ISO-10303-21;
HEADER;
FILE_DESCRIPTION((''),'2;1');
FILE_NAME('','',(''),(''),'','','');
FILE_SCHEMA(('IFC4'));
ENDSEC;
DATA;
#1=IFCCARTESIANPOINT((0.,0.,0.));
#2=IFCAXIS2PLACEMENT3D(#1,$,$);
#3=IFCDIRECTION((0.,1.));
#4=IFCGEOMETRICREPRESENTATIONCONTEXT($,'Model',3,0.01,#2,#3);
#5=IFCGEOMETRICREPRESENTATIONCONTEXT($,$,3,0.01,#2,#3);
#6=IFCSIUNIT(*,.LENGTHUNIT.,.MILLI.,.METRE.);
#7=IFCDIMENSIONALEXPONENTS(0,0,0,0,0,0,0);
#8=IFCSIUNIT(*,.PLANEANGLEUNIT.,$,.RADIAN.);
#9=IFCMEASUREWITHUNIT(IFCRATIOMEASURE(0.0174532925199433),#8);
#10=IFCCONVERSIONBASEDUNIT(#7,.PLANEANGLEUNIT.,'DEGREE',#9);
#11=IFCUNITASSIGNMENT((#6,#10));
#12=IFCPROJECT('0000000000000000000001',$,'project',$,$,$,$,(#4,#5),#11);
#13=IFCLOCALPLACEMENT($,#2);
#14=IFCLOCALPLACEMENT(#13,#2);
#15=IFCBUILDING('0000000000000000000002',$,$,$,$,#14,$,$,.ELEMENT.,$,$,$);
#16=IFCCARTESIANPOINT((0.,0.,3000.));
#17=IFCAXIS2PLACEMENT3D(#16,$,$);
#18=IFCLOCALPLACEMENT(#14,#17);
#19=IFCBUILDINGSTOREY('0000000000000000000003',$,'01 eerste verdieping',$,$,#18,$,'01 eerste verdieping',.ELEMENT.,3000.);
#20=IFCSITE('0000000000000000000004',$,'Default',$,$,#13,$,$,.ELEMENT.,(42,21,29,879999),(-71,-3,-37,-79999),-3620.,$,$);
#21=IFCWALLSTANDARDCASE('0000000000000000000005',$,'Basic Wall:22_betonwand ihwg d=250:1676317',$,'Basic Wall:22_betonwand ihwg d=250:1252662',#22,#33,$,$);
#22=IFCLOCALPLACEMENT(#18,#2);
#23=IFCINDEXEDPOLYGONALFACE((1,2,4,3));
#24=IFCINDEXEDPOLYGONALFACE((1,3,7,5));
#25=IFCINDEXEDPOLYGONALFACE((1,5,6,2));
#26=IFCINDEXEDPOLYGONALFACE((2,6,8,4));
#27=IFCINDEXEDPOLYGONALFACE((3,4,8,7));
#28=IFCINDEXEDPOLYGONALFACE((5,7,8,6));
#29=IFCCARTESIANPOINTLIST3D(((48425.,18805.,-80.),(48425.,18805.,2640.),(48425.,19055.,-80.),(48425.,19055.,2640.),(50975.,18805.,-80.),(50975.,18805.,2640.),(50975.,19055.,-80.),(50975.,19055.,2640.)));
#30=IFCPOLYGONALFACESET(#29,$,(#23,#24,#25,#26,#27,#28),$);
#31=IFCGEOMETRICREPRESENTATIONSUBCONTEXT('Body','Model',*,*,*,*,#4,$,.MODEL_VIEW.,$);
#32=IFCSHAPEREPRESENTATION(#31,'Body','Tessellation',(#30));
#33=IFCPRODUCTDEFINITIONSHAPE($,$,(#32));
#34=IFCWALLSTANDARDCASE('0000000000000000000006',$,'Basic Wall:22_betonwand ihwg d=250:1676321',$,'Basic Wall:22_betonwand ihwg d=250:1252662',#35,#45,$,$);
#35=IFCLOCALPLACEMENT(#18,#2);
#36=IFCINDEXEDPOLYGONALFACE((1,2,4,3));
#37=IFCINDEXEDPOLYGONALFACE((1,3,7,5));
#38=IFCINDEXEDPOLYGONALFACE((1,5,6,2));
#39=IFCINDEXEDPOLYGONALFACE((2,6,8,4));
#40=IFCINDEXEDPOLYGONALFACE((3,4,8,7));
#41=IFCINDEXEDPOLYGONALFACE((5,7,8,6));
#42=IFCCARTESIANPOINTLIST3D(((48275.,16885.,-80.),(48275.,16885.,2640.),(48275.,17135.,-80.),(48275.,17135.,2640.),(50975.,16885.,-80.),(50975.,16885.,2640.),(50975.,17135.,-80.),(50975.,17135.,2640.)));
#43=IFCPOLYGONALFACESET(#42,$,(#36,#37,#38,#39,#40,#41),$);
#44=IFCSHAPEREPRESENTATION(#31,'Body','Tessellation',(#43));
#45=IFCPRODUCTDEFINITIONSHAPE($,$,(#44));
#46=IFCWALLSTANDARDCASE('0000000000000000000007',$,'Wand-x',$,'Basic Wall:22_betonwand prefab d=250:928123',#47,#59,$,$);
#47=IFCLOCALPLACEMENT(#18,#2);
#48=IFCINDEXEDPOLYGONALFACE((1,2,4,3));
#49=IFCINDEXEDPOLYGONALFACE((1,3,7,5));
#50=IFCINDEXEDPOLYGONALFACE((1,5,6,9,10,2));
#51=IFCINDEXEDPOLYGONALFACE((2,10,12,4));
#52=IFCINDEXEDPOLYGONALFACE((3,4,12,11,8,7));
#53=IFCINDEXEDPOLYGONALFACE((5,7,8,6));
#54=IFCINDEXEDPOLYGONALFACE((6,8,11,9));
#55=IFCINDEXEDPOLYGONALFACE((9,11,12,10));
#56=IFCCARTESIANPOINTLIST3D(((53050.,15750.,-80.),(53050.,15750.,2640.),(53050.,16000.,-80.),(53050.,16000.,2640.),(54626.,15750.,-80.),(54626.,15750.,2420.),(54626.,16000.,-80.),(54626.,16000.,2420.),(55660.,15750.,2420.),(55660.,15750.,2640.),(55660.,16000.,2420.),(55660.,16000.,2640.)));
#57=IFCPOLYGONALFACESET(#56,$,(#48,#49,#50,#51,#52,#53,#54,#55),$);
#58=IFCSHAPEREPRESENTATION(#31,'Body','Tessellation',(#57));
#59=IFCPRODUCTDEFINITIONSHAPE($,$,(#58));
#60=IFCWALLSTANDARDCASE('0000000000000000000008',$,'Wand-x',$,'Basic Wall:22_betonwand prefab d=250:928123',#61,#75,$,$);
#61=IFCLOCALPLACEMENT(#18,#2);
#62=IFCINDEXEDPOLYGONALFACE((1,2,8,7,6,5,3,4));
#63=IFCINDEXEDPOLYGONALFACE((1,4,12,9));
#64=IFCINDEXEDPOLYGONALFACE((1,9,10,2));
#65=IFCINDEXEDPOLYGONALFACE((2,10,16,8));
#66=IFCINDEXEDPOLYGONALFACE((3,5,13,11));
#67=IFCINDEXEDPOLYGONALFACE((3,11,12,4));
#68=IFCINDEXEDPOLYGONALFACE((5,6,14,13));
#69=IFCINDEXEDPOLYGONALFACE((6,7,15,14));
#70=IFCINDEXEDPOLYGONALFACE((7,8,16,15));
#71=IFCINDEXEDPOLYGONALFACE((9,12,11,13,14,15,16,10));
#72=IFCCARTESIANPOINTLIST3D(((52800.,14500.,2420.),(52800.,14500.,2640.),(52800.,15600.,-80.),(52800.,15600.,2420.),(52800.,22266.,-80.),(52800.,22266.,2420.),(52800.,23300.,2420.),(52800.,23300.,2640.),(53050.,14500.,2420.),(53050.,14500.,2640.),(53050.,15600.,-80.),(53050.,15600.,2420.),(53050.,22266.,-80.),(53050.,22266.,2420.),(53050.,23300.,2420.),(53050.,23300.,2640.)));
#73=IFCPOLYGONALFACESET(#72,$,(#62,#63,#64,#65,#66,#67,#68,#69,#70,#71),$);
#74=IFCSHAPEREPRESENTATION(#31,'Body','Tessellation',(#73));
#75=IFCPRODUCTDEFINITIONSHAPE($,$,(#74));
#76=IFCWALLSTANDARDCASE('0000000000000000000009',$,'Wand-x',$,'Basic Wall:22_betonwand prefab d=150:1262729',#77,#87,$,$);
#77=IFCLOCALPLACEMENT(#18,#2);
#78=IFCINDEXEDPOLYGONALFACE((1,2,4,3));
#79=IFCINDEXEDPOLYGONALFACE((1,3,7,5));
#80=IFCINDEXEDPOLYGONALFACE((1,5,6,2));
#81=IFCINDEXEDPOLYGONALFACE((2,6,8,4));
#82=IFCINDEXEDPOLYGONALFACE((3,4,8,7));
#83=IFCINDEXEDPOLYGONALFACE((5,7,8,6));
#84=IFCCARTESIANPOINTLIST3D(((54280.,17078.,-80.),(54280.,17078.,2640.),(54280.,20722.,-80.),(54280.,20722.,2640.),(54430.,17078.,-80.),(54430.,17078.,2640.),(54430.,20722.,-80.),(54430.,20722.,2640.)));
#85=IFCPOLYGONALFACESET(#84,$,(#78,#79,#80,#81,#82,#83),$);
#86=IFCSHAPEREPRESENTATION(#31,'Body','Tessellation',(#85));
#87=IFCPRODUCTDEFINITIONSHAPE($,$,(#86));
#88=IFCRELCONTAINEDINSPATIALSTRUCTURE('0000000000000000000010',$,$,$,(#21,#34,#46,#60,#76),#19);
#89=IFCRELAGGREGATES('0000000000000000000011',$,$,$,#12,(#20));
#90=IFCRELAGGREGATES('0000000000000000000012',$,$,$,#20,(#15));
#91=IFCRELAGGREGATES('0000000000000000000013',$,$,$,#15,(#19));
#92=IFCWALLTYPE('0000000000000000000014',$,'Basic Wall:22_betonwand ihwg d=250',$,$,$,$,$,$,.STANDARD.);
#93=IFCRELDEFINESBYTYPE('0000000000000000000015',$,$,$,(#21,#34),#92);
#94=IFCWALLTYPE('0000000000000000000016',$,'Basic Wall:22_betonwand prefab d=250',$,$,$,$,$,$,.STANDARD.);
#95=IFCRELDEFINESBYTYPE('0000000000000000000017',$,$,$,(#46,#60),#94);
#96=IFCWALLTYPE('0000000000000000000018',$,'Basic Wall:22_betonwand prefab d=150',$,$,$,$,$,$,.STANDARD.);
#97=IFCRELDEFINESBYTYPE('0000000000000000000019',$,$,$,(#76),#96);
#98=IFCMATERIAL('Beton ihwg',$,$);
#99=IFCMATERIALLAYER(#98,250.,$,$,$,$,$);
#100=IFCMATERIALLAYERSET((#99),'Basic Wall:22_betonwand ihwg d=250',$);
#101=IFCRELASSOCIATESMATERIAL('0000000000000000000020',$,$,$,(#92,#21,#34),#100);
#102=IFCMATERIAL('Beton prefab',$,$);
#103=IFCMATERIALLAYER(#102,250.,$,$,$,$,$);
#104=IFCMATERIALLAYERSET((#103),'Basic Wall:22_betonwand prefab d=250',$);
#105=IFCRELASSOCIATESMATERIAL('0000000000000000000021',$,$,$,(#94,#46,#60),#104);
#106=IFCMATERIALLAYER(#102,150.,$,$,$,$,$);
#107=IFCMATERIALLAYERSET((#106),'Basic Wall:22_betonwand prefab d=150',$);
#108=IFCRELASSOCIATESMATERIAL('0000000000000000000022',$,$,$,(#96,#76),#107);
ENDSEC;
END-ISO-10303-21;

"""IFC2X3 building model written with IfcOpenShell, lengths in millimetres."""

from ifc_helpers import new_model, entity, si_unit, converted_unit, direction, frame, frame_2d, origin, origin_2d_with_axis, place, context, subcontext, project, spatial, rectangle, extrude, material, layer, layer_set, layer_usage, type_object, element, save


model = new_model("IFC2X3")

# Units and contexts
model_context = context("Model", 3, precision=0.01, world=origin(), true_north=direction((0.0, 1.0)))
context_of_model = context(None, 3, precision=0.01, world=origin(), true_north=direction((0.0, 1.0)))
body_context = subcontext(model_context, "Body", "Model", "MODEL_VIEW")
ifc_project = project(units=[si_unit("LENGTHUNIT", "METRE", prefix="MILLI"), converted_unit("PLANEANGLEUNIT", "DEGREE", entity("IfcRatioMeasure", 0.0174532925199433), si_unit("PLANEANGLEUNIT", "RADIAN"), dimensions=[0, 0, 0, 0, 0, 0, 0])], contexts=[model_context, context_of_model])

# Site, building, storey
site_placement = place(None, origin())
site = spatial("IfcSite", under=ifc_project, at=site_placement, Name="Default", CompositionType="ELEMENT", RefLatitude=(42, 21, 29, 879999), RefLongitude=(-71, -3, -37, -79999), RefElevation=-3620.0)
building_placement = place(site_placement, origin())
building = spatial("IfcBuilding", under=site, at=building_placement, CompositionType="ELEMENT")
storey_placement = place(building_placement, frame((0.0, 0.0, 3000.0)))
storey = spatial("IfcBuildingStorey", under=building, at=storey_placement, Name="01 eerste verdieping", LongName="01 eerste verdieping", CompositionType="ELEMENT", Elevation=3000.0)

# Shared definitions
ifc_material_1 = material(Name="Beton prefab")

# Shared definitions
ifc_material_2 = material(Name="Beton ihwg")
ifc_layer_1 = layer(ifc_material_2, 250.0)
ifc_layer_set_1 = layer_set([ifc_layer_1], Name="Basic Wall:22_betonwand ihwg d=250")
wall_type_1 = type_object("IfcWallType", Name="Basic Wall:22_betonwand ihwg d=250", PredefinedType="STANDARD", material=ifc_layer_set_1)

# Walls
ifc_layer_usage_1 = layer_usage(ifc_layer_set_1, "AXIS2", "POSITIVE", -125.0)
wall_1_placement = place(storey_placement, frame((50975.0, 18930.0, -80.0), z_axis=(0.0, 0.0, 1.0), x_axis=(-1.0, 0.0, 0.0)))
element("IfcWallStandardCase", 1, at=wall_1_placement, inside=storey, type_object=wall_type_1, material=ifc_layer_usage_1, Name="Basic Wall:22_betonwand ihwg d=250:1676317", ObjectType="Basic Wall:22_betonwand ihwg d=250:1252662", context=body_context, shape_type="SweptSolid", body=[
    extrude(rectangle(XDim=2550.0, YDim=250.0, at=frame_2d((1275.0, 0.0), x_axis=(-1.0, 0.0))), origin(), (0.0, 0.0, 1.0), 2720.0),
])
ifc_layer_usage_2 = layer_usage(ifc_layer_set_1, "AXIS2", "POSITIVE", -125.0)
wall_2_placement = place(storey_placement, frame((50975.0, 17010.0, -80.0), z_axis=(0.0, 0.0, 1.0), x_axis=(-1.0, 0.0, 0.0)))
element("IfcWallStandardCase", 2, at=wall_2_placement, inside=storey, type_object=wall_type_1, material=ifc_layer_usage_2, Name="Basic Wall:22_betonwand ihwg d=250:1676321", ObjectType="Basic Wall:22_betonwand ihwg d=250:1252662", context=body_context, shape_type="SweptSolid", body=[
    extrude(rectangle(XDim=2700.0, YDim=250.0, at=frame_2d((1350.0, 0.0), x_axis=(-1.0, 0.0))), origin(), (0.0, 0.0, 1.0), 2720.0),
])

# Wall, opening
ifc_layer_2 = layer(ifc_material_1, 250.0)
ifc_layer_set_2 = layer_set([ifc_layer_2], Name="Basic Wall:22_betonwand prefab d=250")
ifc_layer_usage_3 = layer_usage(ifc_layer_set_2, "AXIS2", "POSITIVE", -125.0)
wall_type_2 = type_object("IfcWallType", Name="Basic Wall:22_betonwand prefab d=250", PredefinedType="STANDARD", material=ifc_layer_set_2)
wall_3_placement = place(storey_placement, frame((53050.0, 15875.0, -80.0)))
wall_3 = element("IfcWallStandardCase", 3, at=wall_3_placement, inside=storey, type_object=wall_type_2, material=ifc_layer_usage_3, Name="Wand-x", ObjectType="Basic Wall:22_betonwand prefab d=250:928123", context=body_context, shape_type="SweptSolid", body=[
    extrude(rectangle(XDim=2610.0, YDim=250.0, at=frame_2d((1305.0, 0.0), x_axis=(-1.0, 0.0))), origin(), (0.0, 0.0, 1.0), 2720.0),
])
opening_1_placement = place(wall_3_placement, frame((-53050.0, -15875.0, 80.0)))
element("IfcOpeningElement", 4, at=opening_1_placement, cuts=wall_3, ObjectType="Opening", context=body_context, shape_type="SweptSolid", body=[
    extrude(rectangle(XDim=2500.0, YDim=1034.0, at=frame_2d((0.0, 0.0), x_axis=(1.0, 0.0))), frame((55143.0, 15475.0, 1170.0), z_axis=(0.0, 1.0, 0.0), x_axis=(0.0, 0.0, -1.0)), (0.0, 0.0, 1.0), 800.0),
])

# Wall, openings
ifc_layer_usage_4 = layer_usage(ifc_layer_set_2, "AXIS2", "NEGATIVE", 125.0)
wall_4_placement = place(storey_placement, frame((52925.0, 14500.0, -80.0), z_axis=(0.0, 0.0, 1.0), x_axis=(0.0, 1.0, 0.0)))
wall_4 = element("IfcWallStandardCase", 5, at=wall_4_placement, inside=storey, type_object=wall_type_2, material=ifc_layer_usage_4, Name="Wand-x", ObjectType="Basic Wall:22_betonwand prefab d=250:928123", context=body_context, shape_type="SweptSolid", body=[
    extrude(rectangle(XDim=8800.0, YDim=250.0, at=frame_2d((4400.0, 0.0), x_axis=(-1.0, 0.0))), origin(), (0.0, 0.0, 1.0), 2720.0),
])
opening_2_placement = place(wall_4_placement, frame((-14500.0, 52925.0, 80.0), z_axis=(0.0, 0.0, 1.0), x_axis=(0.0, -1.0, 0.0)))
element("IfcOpeningElement", 6, at=opening_2_placement, cuts=wall_4, ObjectType="Opening", context=body_context, shape_type="SweptSolid", body=[
    extrude(rectangle(XDim=2500.0, YDim=1034.0, at=origin_2d_with_axis()), frame((53325.0, 22783.0, 1170.0), z_axis=(-1.0, 0.0, 0.0), x_axis=(0.0, 0.0, -1.0)), (0.0, 0.0, 1.0), 800.0),
])
opening_3_placement = place(wall_4_placement, frame((-14500.0, 52925.0, 80.0), z_axis=(0.0, 0.0, 1.0), x_axis=(0.0, -1.0, 0.0)))
element("IfcOpeningElement", 7, at=opening_3_placement, cuts=wall_4, ObjectType="Opening", context=body_context, shape_type="SweptSolid", body=[
    extrude(rectangle(XDim=2500.0, YDim=1100.0, at=frame_2d((0.0, 0.0), x_axis=(0.0, 1.0))), frame((53325.0, 15050.0, 1170.0), z_axis=(-1.0, 0.0, 0.0), x_axis=(0.0, 1.0, 0.0)), (0.0, 0.0, 1.0), 800.0),
])

# Wall
ifc_layer_3 = layer(ifc_material_1, 150.0)
ifc_layer_set_3 = layer_set([ifc_layer_3], Name="Basic Wall:22_betonwand prefab d=150")
ifc_layer_usage_5 = layer_usage(ifc_layer_set_3, "AXIS2", "NEGATIVE", 75.0)
wall_type_3 = type_object("IfcWallType", Name="Basic Wall:22_betonwand prefab d=150", PredefinedType="STANDARD", material=ifc_layer_set_3)
wall_5_placement = place(storey_placement, frame((54355.0, 17078.0, -80.0), z_axis=(0.0, 0.0, 1.0), x_axis=(0.0, 1.0, 0.0)))
element("IfcWallStandardCase", 8, at=wall_5_placement, inside=storey, type_object=wall_type_3, material=ifc_layer_usage_5, Name="Wand-x", ObjectType="Basic Wall:22_betonwand prefab d=150:1262729", context=body_context, shape_type="SweptSolid", body=[
    extrude(rectangle(XDim=3644.0, YDim=150.0, at=frame_2d((1822.0, 0.0), x_axis=(-1.0, 0.0))), origin(), (0.0, 0.0, 1.0), 2720.0),
])

save(model, "model.ifc")
